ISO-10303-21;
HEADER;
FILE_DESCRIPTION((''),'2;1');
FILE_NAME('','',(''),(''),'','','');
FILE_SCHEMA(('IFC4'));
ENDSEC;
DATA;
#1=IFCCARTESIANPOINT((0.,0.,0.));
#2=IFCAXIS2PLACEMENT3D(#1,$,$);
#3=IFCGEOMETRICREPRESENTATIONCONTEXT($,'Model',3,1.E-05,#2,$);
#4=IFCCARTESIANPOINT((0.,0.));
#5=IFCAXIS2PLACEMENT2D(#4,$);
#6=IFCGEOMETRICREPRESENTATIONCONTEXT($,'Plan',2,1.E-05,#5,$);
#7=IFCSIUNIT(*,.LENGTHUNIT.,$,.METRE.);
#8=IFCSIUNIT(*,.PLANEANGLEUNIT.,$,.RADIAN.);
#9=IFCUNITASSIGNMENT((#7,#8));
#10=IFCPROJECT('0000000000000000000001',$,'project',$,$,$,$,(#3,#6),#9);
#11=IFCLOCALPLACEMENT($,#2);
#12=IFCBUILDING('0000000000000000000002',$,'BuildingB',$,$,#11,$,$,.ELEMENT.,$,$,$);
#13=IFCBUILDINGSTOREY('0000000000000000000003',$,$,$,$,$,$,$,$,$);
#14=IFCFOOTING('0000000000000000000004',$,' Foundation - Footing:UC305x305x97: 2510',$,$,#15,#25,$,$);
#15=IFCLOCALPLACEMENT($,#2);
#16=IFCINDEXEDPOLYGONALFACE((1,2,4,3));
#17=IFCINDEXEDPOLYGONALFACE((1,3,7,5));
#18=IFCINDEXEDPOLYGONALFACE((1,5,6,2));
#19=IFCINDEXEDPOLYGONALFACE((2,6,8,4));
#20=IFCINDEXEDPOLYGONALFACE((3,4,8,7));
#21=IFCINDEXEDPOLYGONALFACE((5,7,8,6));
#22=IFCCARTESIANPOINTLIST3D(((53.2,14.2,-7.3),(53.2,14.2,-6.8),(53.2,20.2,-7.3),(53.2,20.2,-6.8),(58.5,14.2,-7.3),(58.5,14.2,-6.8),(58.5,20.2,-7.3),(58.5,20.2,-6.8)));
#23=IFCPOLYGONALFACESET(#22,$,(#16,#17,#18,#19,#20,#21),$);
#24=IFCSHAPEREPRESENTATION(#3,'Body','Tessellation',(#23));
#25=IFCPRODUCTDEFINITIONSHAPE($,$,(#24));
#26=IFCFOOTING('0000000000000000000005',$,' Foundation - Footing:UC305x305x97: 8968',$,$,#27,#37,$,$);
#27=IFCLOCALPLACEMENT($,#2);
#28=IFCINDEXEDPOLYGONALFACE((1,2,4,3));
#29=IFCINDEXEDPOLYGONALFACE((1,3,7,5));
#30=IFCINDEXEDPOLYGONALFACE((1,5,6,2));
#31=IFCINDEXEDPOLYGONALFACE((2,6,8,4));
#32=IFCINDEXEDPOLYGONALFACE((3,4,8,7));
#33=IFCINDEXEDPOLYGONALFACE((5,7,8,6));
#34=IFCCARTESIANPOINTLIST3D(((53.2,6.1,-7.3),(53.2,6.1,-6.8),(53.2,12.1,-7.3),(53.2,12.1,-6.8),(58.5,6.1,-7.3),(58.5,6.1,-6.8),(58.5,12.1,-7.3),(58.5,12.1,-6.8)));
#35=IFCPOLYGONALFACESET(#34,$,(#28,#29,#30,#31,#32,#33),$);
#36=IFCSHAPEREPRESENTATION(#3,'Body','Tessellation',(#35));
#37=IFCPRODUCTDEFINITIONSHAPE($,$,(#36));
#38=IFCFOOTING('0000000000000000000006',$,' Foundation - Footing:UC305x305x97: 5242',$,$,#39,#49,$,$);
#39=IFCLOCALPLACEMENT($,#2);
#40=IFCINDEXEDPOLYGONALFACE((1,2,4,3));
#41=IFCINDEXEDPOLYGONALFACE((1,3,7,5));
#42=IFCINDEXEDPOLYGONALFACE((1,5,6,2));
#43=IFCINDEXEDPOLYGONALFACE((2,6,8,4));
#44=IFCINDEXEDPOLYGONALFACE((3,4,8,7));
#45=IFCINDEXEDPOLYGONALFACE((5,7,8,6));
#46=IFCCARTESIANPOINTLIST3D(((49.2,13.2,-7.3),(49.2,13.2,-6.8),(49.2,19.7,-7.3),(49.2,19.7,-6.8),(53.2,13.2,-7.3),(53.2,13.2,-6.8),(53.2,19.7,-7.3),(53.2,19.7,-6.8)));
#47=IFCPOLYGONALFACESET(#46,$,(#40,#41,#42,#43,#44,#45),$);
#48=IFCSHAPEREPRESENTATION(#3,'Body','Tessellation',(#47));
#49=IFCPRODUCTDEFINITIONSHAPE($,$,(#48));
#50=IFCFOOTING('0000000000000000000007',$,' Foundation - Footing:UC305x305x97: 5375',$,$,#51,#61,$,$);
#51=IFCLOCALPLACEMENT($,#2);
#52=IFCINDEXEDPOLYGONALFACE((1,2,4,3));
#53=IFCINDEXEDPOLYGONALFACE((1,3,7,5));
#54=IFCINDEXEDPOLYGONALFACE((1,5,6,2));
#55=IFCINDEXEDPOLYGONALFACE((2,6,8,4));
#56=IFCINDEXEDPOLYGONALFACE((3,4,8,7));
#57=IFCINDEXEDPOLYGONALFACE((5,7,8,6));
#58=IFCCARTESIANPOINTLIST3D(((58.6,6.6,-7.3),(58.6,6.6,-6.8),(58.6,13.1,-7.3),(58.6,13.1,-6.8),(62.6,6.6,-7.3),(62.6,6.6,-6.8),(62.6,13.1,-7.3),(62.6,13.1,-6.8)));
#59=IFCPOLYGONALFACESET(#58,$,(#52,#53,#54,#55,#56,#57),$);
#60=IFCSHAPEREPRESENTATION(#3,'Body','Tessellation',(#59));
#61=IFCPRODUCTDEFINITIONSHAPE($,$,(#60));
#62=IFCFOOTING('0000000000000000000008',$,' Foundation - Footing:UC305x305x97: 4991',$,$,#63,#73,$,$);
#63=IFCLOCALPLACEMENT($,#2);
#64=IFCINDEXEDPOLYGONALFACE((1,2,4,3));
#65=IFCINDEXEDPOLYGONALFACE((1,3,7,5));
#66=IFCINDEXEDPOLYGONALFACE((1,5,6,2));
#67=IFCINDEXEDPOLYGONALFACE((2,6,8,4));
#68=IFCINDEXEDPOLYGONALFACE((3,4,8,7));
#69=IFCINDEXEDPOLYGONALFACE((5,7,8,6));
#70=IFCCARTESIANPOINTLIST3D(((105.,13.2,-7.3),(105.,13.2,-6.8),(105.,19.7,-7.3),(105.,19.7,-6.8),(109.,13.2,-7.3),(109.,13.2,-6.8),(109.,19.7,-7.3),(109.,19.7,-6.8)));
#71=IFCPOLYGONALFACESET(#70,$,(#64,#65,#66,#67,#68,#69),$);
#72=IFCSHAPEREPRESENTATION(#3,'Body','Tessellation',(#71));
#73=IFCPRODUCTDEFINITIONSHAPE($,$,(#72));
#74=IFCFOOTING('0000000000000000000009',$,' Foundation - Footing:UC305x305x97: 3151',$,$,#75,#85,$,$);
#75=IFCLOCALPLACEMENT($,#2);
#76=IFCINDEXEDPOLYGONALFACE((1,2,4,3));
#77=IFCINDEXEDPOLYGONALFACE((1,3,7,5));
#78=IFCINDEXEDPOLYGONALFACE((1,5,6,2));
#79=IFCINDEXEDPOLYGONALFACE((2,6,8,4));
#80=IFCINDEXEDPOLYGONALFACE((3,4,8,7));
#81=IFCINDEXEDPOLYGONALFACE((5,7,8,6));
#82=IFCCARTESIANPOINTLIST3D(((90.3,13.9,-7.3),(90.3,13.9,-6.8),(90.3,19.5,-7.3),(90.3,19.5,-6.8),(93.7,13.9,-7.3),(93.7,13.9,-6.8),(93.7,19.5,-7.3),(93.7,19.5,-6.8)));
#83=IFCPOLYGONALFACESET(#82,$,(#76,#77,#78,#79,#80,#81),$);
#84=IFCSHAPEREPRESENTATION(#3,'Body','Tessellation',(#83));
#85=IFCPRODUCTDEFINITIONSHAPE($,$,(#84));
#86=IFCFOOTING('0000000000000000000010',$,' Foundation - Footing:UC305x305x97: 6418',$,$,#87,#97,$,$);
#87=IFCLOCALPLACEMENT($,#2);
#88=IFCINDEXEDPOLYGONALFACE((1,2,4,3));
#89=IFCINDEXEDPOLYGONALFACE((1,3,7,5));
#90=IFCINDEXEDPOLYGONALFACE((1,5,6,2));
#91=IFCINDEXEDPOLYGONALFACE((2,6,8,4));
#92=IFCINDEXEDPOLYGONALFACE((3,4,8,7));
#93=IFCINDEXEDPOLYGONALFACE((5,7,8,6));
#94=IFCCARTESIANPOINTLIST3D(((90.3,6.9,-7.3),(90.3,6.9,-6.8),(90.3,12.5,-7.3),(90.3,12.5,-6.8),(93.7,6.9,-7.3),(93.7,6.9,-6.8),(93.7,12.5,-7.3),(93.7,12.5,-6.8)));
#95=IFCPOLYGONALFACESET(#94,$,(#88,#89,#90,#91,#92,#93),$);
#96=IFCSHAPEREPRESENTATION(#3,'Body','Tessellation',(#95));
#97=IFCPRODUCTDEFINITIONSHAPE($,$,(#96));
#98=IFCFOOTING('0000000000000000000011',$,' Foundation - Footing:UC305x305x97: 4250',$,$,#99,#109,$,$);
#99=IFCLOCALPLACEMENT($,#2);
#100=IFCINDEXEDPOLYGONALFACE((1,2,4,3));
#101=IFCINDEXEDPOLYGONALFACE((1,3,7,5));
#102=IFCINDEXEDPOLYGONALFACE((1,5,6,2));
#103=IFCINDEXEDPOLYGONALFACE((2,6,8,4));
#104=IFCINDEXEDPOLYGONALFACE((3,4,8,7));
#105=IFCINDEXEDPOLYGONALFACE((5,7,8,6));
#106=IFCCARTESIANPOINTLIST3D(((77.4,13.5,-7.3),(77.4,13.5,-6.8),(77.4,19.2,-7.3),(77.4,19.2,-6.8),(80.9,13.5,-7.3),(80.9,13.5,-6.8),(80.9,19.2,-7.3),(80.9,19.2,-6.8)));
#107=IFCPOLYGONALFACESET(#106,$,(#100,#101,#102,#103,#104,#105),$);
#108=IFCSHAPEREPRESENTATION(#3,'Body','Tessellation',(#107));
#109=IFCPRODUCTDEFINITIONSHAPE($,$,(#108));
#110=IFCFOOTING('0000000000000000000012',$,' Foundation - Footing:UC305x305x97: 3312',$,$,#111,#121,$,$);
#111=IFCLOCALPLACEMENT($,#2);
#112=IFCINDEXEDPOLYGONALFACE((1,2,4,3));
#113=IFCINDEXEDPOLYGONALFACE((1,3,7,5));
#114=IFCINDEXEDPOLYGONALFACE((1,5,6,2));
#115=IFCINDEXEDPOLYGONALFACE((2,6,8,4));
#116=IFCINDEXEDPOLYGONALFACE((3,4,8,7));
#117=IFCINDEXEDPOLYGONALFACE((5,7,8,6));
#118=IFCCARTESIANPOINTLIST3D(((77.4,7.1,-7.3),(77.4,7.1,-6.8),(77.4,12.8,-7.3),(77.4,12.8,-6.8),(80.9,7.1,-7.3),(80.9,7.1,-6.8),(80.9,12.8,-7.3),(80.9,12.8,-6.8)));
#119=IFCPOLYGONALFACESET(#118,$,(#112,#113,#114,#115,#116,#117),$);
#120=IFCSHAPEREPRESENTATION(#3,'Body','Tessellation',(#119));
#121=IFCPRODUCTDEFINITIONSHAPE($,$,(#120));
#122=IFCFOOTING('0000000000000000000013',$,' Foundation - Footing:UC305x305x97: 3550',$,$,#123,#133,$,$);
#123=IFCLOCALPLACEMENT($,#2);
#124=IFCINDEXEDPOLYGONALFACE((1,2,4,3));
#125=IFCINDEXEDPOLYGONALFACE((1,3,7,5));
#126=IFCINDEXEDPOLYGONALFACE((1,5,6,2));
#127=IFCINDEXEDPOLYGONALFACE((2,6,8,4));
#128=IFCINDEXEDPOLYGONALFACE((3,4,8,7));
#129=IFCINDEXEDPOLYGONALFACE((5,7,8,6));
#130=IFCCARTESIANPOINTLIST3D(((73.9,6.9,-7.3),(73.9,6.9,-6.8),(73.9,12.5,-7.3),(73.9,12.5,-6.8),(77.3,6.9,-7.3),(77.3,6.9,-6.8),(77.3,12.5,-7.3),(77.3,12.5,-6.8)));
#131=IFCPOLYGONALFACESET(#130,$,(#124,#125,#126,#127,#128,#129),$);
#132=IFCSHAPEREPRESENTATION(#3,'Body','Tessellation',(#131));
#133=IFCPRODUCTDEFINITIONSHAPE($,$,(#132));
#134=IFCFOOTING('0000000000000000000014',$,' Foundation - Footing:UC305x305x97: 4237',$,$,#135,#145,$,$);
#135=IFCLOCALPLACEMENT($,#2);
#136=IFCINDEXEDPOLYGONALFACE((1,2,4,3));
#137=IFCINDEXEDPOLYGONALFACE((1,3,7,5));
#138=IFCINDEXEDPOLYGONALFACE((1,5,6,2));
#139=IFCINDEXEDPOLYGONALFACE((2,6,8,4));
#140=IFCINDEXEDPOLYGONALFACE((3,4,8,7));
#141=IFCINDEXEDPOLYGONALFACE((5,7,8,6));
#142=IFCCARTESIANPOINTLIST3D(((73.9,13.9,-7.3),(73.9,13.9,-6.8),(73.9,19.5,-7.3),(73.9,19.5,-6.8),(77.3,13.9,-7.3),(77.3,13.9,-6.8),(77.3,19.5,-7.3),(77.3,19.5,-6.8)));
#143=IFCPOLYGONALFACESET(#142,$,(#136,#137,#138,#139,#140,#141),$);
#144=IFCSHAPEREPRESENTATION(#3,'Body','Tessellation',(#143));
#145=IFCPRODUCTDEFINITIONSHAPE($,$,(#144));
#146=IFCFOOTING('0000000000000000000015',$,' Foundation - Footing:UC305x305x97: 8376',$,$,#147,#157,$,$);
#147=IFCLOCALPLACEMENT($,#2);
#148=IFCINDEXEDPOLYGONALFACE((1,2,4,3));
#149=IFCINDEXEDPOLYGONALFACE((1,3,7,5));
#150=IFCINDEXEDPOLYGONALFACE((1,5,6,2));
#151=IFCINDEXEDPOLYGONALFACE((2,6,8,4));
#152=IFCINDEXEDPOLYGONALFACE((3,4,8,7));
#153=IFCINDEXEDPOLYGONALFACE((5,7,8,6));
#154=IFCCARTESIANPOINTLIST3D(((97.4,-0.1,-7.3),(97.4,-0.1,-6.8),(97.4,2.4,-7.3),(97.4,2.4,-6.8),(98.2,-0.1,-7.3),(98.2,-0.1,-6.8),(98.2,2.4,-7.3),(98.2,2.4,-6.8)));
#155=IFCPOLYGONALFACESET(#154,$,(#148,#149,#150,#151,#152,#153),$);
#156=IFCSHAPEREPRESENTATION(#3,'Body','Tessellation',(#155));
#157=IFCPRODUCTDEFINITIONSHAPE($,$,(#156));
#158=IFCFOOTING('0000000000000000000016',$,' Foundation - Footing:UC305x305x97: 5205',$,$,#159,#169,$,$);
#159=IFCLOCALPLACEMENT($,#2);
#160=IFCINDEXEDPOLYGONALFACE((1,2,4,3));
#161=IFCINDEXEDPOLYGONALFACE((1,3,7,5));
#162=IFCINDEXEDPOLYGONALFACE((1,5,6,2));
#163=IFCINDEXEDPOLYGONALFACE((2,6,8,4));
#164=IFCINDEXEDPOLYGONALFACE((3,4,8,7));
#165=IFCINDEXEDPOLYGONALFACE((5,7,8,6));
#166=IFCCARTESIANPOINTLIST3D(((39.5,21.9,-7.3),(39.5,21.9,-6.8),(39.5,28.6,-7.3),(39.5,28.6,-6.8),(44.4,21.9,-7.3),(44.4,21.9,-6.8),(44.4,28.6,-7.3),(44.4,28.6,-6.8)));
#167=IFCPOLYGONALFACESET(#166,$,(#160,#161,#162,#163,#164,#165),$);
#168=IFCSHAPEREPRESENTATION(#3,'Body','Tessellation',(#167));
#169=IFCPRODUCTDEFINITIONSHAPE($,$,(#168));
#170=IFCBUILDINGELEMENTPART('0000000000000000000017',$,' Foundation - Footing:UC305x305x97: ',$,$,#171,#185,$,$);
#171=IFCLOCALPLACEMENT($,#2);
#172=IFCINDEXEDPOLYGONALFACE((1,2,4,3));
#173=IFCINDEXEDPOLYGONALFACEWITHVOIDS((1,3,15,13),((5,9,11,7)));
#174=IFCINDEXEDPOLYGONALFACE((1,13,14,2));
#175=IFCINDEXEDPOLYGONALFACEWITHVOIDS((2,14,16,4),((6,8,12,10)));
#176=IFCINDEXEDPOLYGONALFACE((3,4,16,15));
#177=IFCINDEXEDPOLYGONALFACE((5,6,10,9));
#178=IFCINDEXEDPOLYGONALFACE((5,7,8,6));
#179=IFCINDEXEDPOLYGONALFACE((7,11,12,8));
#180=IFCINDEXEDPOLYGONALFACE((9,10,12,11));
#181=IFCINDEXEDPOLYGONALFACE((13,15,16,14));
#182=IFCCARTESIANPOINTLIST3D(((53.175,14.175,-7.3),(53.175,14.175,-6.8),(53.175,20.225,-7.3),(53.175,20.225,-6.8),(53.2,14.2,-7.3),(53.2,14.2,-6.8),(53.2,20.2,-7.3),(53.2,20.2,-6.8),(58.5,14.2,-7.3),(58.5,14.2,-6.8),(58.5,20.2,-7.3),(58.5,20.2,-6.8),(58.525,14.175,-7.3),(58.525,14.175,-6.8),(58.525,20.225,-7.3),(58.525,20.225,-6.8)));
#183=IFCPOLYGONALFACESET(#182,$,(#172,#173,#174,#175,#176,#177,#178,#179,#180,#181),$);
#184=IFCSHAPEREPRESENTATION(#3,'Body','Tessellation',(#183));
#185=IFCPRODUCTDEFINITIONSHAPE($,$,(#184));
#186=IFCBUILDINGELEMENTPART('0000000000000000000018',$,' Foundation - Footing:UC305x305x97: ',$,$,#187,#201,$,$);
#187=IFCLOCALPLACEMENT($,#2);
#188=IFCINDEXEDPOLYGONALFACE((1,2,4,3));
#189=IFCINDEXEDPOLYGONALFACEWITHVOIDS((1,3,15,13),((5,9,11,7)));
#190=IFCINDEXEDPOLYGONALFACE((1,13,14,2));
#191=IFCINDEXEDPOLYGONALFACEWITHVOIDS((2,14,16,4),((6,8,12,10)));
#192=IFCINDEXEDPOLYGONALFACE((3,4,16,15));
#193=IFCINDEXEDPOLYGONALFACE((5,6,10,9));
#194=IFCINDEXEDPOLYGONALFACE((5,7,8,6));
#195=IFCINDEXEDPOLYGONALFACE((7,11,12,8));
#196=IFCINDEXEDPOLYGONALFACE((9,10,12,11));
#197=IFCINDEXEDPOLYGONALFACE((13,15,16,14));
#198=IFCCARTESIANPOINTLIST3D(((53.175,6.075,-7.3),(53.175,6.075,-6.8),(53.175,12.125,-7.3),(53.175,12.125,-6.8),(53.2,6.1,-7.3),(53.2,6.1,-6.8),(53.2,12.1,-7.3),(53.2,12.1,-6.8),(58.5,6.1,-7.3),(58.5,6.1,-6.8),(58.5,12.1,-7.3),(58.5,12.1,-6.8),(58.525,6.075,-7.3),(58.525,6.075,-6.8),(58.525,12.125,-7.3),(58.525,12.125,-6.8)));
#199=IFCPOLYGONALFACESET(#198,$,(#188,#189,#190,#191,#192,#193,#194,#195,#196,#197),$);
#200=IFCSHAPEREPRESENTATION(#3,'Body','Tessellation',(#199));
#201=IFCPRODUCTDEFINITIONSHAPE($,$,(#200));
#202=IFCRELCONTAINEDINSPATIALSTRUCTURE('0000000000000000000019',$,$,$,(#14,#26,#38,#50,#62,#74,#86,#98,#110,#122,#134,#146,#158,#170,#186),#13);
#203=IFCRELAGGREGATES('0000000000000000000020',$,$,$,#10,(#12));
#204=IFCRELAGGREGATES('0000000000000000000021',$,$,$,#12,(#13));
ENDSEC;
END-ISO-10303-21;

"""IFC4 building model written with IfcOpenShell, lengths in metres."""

from ifc_helpers import new_model, si_unit, origin, origin_2d, place, context, project, spatial, polyline, outline, extrude, element, save


model = new_model("IFC4")

# Units and contexts
model_context = context("Model", 3, precision=1e-05, world=origin())
plan_context = context("Plan", 2, precision=1e-05, world=origin_2d())
ifc_project = project(units=[si_unit("LENGTHUNIT", "METRE"), si_unit("PLANEANGLEUNIT", "RADIAN")], contexts=[model_context, plan_context])

# Building, storey
building_placement = place(None, origin())
building = spatial("IfcBuilding", under=ifc_project, at=building_placement, Name="BuildingB", CompositionType="ELEMENT")
storey = spatial("IfcBuildingStorey", under=building)

# Footings
element("IfcFooting", 1, inside=storey, Name=" Foundation - Footing:UC305x305x97: 2510", context=model_context, shape_type="SweptSolid", body=[
    extrude(outline(polyline([(58.5, 20.2, -7.3), (53.2, 20.2, -7.3), (53.2, 14.2, -7.3), (58.5, 14.2, -7.3), (58.5, 20.2, -7.3)])), None, (0.0, 0.0, 1.0), 0.5),
])
element("IfcFooting", 2, inside=storey, Name=" Foundation - Footing:UC305x305x97: 8968", context=model_context, shape_type="SweptSolid", body=[
    extrude(outline(polyline([(58.5, 12.1, -7.3), (53.2, 12.1, -7.3), (53.2, 6.1, -7.3), (58.5, 6.1, -7.3), (58.5, 12.1, -7.3)])), None, (0.0, 0.0, 1.0), 0.5),
])
element("IfcFooting", 3, inside=storey, Name=" Foundation - Footing:UC305x305x97: 5242", context=model_context, shape_type="SweptSolid", body=[
    extrude(outline(polyline([(53.2, 19.7, -7.3), (49.2, 19.7, -7.3), (49.2, 13.2, -7.3), (53.2, 13.2, -7.3), (53.2, 19.7, -7.3)])), None, (0.0, 0.0, 1.0), 0.5),
])
element("IfcFooting", 4, inside=storey, Name=" Foundation - Footing:UC305x305x97: 5375", context=model_context, shape_type="SweptSolid", body=[
    extrude(outline(polyline([(58.6, 13.1, -7.3), (62.6, 13.1, -7.3), (62.6, 6.6, -7.3), (58.6, 6.6, -7.3), (58.6, 13.1, -7.3)])), None, (0.0, 0.0, 1.0), 0.5),
])
element("IfcFooting", 5, inside=storey, Name=" Foundation - Footing:UC305x305x97: 4991", context=model_context, shape_type="SweptSolid", body=[
    extrude(outline(polyline([(109.0, 19.7, -7.3), (105.0, 19.7, -7.3), (105.0, 13.2, -7.3), (109.0, 13.2, -7.3), (109.0, 19.7, -7.3)])), None, (0.0, 0.0, 1.0), 0.5),
])
element("IfcFooting", 6, inside=storey, Name=" Foundation - Footing:UC305x305x97: 3151", context=model_context, shape_type="SweptSolid", body=[
    extrude(outline(polyline([(90.3, 19.5, -7.3), (93.7, 19.5, -7.3), (93.7, 13.9, -7.3), (90.3, 13.9, -7.3), (90.3, 19.5, -7.3)])), None, (0.0, 0.0, 1.0), 0.5),
])
element("IfcFooting", 7, inside=storey, Name=" Foundation - Footing:UC305x305x97: 6418", context=model_context, shape_type="SweptSolid", body=[
    extrude(outline(polyline([(90.3, 12.5, -7.3), (93.7, 12.5, -7.3), (93.7, 6.9, -7.3), (90.3, 6.9, -7.3), (90.3, 12.5, -7.3)])), None, (0.0, 0.0, 1.0), 0.5),
])
element("IfcFooting", 8, inside=storey, Name=" Foundation - Footing:UC305x305x97: 4250", context=model_context, shape_type="SweptSolid", body=[
    extrude(outline(polyline([(77.4, 19.2, -7.3), (80.9, 19.2, -7.3), (80.9, 13.5, -7.3), (77.4, 13.5, -7.3), (77.4, 19.2, -7.3)])), None, (0.0, 0.0, 1.0), 0.5),
])
element("IfcFooting", 9, inside=storey, Name=" Foundation - Footing:UC305x305x97: 3312", context=model_context, shape_type="SweptSolid", body=[
    extrude(outline(polyline([(77.4, 12.8, -7.3), (80.9, 12.8, -7.3), (80.9, 7.1, -7.3), (77.4, 7.1, -7.3), (77.4, 12.8, -7.3)])), None, (0.0, 0.0, 1.0), 0.5),
])
element("IfcFooting", 10, inside=storey, Name=" Foundation - Footing:UC305x305x97: 3550", context=model_context, shape_type="SweptSolid", body=[
    extrude(outline(polyline([(73.9, 12.5, -7.3), (77.3, 12.5, -7.3), (77.3, 6.9, -7.3), (73.9, 6.9, -7.3), (73.9, 12.5, -7.3)])), None, (0.0, 0.0, 1.0), 0.5),
])
element("IfcFooting", 11, inside=storey, Name=" Foundation - Footing:UC305x305x97: 4237", context=model_context, shape_type="SweptSolid", body=[
    extrude(outline(polyline([(73.9, 19.5, -7.3), (77.3, 19.5, -7.3), (77.3, 13.9, -7.3), (73.9, 13.9, -7.3), (73.9, 19.5, -7.3)])), None, (0.0, 0.0, 1.0), 0.5),
])
element("IfcFooting", 12, inside=storey, Name=" Foundation - Footing:UC305x305x97: 8376", context=model_context, shape_type="SweptSolid", body=[
    extrude(outline(polyline([(97.4, 2.4, -7.3), (98.2, 2.4, -7.3), (98.2, -0.1, -7.3), (97.4, -0.1, -7.3), (97.4, 2.4, -7.3)])), None, (0.0, 0.0, 1.0), 0.5),
])
element("IfcFooting", 13, inside=storey, Name=" Foundation - Footing:UC305x305x97: 5205", context=model_context, shape_type="SweptSolid", body=[
    extrude(outline(polyline([(44.4, 21.9, -7.3), (44.4, 28.6, -7.3), (39.5, 28.6, -7.3), (39.5, 21.9, -7.3), (44.4, 21.9, -7.3)])), None, (0.0, 0.0, 1.0), 0.5),
])

# Building element parts, openings
building_element_part_1 = element("IfcBuildingElementPart", 14, inside=storey, Name=" Foundation - Footing:UC305x305x97: ", context=model_context, shape_type="SweptSolid", body=[
    extrude(outline(polyline([(58.525, 20.225, -7.3), (53.175, 20.225, -7.3), (53.175, 14.175, -7.3), (58.525, 14.175, -7.3), (58.525, 20.225, -7.3)])), None, (0.0, 0.0, 1.0), 0.5),
])
element("IfcOpeningElement", 15, inside=storey, cuts=building_element_part_1, context=model_context, shape_type="SweptSolid", body=[
    extrude(outline(polyline([(58.5, 20.2, -7.3), (53.2, 20.2, -7.3), (53.2, 14.2, -7.3), (58.5, 14.2, -7.3), (58.5, 20.2, -7.3)])), None, (0.0, 0.0, 1.0), 0.5),
])
building_element_part_2 = element("IfcBuildingElementPart", 16, inside=storey, Name=" Foundation - Footing:UC305x305x97: ", context=model_context, shape_type="SweptSolid", body=[
    extrude(outline(polyline([(58.525, 12.125, -7.3), (53.175, 12.125, -7.3), (53.175, 6.075, -7.3), (58.525, 6.075, -7.3), (58.525, 12.125, -7.3)])), None, (0.0, 0.0, 1.0), 0.5),
])
element("IfcOpeningElement", 17, inside=storey, cuts=building_element_part_2, context=model_context, shape_type="SweptSolid", body=[
    extrude(outline(polyline([(58.5, 12.1, -7.3), (53.2, 12.1, -7.3), (53.2, 6.1, -7.3), (58.5, 6.1, -7.3), (58.5, 12.1, -7.3)])), None, (0.0, 0.0, 1.0), 0.5),
])

save(model, "model.ifc")
